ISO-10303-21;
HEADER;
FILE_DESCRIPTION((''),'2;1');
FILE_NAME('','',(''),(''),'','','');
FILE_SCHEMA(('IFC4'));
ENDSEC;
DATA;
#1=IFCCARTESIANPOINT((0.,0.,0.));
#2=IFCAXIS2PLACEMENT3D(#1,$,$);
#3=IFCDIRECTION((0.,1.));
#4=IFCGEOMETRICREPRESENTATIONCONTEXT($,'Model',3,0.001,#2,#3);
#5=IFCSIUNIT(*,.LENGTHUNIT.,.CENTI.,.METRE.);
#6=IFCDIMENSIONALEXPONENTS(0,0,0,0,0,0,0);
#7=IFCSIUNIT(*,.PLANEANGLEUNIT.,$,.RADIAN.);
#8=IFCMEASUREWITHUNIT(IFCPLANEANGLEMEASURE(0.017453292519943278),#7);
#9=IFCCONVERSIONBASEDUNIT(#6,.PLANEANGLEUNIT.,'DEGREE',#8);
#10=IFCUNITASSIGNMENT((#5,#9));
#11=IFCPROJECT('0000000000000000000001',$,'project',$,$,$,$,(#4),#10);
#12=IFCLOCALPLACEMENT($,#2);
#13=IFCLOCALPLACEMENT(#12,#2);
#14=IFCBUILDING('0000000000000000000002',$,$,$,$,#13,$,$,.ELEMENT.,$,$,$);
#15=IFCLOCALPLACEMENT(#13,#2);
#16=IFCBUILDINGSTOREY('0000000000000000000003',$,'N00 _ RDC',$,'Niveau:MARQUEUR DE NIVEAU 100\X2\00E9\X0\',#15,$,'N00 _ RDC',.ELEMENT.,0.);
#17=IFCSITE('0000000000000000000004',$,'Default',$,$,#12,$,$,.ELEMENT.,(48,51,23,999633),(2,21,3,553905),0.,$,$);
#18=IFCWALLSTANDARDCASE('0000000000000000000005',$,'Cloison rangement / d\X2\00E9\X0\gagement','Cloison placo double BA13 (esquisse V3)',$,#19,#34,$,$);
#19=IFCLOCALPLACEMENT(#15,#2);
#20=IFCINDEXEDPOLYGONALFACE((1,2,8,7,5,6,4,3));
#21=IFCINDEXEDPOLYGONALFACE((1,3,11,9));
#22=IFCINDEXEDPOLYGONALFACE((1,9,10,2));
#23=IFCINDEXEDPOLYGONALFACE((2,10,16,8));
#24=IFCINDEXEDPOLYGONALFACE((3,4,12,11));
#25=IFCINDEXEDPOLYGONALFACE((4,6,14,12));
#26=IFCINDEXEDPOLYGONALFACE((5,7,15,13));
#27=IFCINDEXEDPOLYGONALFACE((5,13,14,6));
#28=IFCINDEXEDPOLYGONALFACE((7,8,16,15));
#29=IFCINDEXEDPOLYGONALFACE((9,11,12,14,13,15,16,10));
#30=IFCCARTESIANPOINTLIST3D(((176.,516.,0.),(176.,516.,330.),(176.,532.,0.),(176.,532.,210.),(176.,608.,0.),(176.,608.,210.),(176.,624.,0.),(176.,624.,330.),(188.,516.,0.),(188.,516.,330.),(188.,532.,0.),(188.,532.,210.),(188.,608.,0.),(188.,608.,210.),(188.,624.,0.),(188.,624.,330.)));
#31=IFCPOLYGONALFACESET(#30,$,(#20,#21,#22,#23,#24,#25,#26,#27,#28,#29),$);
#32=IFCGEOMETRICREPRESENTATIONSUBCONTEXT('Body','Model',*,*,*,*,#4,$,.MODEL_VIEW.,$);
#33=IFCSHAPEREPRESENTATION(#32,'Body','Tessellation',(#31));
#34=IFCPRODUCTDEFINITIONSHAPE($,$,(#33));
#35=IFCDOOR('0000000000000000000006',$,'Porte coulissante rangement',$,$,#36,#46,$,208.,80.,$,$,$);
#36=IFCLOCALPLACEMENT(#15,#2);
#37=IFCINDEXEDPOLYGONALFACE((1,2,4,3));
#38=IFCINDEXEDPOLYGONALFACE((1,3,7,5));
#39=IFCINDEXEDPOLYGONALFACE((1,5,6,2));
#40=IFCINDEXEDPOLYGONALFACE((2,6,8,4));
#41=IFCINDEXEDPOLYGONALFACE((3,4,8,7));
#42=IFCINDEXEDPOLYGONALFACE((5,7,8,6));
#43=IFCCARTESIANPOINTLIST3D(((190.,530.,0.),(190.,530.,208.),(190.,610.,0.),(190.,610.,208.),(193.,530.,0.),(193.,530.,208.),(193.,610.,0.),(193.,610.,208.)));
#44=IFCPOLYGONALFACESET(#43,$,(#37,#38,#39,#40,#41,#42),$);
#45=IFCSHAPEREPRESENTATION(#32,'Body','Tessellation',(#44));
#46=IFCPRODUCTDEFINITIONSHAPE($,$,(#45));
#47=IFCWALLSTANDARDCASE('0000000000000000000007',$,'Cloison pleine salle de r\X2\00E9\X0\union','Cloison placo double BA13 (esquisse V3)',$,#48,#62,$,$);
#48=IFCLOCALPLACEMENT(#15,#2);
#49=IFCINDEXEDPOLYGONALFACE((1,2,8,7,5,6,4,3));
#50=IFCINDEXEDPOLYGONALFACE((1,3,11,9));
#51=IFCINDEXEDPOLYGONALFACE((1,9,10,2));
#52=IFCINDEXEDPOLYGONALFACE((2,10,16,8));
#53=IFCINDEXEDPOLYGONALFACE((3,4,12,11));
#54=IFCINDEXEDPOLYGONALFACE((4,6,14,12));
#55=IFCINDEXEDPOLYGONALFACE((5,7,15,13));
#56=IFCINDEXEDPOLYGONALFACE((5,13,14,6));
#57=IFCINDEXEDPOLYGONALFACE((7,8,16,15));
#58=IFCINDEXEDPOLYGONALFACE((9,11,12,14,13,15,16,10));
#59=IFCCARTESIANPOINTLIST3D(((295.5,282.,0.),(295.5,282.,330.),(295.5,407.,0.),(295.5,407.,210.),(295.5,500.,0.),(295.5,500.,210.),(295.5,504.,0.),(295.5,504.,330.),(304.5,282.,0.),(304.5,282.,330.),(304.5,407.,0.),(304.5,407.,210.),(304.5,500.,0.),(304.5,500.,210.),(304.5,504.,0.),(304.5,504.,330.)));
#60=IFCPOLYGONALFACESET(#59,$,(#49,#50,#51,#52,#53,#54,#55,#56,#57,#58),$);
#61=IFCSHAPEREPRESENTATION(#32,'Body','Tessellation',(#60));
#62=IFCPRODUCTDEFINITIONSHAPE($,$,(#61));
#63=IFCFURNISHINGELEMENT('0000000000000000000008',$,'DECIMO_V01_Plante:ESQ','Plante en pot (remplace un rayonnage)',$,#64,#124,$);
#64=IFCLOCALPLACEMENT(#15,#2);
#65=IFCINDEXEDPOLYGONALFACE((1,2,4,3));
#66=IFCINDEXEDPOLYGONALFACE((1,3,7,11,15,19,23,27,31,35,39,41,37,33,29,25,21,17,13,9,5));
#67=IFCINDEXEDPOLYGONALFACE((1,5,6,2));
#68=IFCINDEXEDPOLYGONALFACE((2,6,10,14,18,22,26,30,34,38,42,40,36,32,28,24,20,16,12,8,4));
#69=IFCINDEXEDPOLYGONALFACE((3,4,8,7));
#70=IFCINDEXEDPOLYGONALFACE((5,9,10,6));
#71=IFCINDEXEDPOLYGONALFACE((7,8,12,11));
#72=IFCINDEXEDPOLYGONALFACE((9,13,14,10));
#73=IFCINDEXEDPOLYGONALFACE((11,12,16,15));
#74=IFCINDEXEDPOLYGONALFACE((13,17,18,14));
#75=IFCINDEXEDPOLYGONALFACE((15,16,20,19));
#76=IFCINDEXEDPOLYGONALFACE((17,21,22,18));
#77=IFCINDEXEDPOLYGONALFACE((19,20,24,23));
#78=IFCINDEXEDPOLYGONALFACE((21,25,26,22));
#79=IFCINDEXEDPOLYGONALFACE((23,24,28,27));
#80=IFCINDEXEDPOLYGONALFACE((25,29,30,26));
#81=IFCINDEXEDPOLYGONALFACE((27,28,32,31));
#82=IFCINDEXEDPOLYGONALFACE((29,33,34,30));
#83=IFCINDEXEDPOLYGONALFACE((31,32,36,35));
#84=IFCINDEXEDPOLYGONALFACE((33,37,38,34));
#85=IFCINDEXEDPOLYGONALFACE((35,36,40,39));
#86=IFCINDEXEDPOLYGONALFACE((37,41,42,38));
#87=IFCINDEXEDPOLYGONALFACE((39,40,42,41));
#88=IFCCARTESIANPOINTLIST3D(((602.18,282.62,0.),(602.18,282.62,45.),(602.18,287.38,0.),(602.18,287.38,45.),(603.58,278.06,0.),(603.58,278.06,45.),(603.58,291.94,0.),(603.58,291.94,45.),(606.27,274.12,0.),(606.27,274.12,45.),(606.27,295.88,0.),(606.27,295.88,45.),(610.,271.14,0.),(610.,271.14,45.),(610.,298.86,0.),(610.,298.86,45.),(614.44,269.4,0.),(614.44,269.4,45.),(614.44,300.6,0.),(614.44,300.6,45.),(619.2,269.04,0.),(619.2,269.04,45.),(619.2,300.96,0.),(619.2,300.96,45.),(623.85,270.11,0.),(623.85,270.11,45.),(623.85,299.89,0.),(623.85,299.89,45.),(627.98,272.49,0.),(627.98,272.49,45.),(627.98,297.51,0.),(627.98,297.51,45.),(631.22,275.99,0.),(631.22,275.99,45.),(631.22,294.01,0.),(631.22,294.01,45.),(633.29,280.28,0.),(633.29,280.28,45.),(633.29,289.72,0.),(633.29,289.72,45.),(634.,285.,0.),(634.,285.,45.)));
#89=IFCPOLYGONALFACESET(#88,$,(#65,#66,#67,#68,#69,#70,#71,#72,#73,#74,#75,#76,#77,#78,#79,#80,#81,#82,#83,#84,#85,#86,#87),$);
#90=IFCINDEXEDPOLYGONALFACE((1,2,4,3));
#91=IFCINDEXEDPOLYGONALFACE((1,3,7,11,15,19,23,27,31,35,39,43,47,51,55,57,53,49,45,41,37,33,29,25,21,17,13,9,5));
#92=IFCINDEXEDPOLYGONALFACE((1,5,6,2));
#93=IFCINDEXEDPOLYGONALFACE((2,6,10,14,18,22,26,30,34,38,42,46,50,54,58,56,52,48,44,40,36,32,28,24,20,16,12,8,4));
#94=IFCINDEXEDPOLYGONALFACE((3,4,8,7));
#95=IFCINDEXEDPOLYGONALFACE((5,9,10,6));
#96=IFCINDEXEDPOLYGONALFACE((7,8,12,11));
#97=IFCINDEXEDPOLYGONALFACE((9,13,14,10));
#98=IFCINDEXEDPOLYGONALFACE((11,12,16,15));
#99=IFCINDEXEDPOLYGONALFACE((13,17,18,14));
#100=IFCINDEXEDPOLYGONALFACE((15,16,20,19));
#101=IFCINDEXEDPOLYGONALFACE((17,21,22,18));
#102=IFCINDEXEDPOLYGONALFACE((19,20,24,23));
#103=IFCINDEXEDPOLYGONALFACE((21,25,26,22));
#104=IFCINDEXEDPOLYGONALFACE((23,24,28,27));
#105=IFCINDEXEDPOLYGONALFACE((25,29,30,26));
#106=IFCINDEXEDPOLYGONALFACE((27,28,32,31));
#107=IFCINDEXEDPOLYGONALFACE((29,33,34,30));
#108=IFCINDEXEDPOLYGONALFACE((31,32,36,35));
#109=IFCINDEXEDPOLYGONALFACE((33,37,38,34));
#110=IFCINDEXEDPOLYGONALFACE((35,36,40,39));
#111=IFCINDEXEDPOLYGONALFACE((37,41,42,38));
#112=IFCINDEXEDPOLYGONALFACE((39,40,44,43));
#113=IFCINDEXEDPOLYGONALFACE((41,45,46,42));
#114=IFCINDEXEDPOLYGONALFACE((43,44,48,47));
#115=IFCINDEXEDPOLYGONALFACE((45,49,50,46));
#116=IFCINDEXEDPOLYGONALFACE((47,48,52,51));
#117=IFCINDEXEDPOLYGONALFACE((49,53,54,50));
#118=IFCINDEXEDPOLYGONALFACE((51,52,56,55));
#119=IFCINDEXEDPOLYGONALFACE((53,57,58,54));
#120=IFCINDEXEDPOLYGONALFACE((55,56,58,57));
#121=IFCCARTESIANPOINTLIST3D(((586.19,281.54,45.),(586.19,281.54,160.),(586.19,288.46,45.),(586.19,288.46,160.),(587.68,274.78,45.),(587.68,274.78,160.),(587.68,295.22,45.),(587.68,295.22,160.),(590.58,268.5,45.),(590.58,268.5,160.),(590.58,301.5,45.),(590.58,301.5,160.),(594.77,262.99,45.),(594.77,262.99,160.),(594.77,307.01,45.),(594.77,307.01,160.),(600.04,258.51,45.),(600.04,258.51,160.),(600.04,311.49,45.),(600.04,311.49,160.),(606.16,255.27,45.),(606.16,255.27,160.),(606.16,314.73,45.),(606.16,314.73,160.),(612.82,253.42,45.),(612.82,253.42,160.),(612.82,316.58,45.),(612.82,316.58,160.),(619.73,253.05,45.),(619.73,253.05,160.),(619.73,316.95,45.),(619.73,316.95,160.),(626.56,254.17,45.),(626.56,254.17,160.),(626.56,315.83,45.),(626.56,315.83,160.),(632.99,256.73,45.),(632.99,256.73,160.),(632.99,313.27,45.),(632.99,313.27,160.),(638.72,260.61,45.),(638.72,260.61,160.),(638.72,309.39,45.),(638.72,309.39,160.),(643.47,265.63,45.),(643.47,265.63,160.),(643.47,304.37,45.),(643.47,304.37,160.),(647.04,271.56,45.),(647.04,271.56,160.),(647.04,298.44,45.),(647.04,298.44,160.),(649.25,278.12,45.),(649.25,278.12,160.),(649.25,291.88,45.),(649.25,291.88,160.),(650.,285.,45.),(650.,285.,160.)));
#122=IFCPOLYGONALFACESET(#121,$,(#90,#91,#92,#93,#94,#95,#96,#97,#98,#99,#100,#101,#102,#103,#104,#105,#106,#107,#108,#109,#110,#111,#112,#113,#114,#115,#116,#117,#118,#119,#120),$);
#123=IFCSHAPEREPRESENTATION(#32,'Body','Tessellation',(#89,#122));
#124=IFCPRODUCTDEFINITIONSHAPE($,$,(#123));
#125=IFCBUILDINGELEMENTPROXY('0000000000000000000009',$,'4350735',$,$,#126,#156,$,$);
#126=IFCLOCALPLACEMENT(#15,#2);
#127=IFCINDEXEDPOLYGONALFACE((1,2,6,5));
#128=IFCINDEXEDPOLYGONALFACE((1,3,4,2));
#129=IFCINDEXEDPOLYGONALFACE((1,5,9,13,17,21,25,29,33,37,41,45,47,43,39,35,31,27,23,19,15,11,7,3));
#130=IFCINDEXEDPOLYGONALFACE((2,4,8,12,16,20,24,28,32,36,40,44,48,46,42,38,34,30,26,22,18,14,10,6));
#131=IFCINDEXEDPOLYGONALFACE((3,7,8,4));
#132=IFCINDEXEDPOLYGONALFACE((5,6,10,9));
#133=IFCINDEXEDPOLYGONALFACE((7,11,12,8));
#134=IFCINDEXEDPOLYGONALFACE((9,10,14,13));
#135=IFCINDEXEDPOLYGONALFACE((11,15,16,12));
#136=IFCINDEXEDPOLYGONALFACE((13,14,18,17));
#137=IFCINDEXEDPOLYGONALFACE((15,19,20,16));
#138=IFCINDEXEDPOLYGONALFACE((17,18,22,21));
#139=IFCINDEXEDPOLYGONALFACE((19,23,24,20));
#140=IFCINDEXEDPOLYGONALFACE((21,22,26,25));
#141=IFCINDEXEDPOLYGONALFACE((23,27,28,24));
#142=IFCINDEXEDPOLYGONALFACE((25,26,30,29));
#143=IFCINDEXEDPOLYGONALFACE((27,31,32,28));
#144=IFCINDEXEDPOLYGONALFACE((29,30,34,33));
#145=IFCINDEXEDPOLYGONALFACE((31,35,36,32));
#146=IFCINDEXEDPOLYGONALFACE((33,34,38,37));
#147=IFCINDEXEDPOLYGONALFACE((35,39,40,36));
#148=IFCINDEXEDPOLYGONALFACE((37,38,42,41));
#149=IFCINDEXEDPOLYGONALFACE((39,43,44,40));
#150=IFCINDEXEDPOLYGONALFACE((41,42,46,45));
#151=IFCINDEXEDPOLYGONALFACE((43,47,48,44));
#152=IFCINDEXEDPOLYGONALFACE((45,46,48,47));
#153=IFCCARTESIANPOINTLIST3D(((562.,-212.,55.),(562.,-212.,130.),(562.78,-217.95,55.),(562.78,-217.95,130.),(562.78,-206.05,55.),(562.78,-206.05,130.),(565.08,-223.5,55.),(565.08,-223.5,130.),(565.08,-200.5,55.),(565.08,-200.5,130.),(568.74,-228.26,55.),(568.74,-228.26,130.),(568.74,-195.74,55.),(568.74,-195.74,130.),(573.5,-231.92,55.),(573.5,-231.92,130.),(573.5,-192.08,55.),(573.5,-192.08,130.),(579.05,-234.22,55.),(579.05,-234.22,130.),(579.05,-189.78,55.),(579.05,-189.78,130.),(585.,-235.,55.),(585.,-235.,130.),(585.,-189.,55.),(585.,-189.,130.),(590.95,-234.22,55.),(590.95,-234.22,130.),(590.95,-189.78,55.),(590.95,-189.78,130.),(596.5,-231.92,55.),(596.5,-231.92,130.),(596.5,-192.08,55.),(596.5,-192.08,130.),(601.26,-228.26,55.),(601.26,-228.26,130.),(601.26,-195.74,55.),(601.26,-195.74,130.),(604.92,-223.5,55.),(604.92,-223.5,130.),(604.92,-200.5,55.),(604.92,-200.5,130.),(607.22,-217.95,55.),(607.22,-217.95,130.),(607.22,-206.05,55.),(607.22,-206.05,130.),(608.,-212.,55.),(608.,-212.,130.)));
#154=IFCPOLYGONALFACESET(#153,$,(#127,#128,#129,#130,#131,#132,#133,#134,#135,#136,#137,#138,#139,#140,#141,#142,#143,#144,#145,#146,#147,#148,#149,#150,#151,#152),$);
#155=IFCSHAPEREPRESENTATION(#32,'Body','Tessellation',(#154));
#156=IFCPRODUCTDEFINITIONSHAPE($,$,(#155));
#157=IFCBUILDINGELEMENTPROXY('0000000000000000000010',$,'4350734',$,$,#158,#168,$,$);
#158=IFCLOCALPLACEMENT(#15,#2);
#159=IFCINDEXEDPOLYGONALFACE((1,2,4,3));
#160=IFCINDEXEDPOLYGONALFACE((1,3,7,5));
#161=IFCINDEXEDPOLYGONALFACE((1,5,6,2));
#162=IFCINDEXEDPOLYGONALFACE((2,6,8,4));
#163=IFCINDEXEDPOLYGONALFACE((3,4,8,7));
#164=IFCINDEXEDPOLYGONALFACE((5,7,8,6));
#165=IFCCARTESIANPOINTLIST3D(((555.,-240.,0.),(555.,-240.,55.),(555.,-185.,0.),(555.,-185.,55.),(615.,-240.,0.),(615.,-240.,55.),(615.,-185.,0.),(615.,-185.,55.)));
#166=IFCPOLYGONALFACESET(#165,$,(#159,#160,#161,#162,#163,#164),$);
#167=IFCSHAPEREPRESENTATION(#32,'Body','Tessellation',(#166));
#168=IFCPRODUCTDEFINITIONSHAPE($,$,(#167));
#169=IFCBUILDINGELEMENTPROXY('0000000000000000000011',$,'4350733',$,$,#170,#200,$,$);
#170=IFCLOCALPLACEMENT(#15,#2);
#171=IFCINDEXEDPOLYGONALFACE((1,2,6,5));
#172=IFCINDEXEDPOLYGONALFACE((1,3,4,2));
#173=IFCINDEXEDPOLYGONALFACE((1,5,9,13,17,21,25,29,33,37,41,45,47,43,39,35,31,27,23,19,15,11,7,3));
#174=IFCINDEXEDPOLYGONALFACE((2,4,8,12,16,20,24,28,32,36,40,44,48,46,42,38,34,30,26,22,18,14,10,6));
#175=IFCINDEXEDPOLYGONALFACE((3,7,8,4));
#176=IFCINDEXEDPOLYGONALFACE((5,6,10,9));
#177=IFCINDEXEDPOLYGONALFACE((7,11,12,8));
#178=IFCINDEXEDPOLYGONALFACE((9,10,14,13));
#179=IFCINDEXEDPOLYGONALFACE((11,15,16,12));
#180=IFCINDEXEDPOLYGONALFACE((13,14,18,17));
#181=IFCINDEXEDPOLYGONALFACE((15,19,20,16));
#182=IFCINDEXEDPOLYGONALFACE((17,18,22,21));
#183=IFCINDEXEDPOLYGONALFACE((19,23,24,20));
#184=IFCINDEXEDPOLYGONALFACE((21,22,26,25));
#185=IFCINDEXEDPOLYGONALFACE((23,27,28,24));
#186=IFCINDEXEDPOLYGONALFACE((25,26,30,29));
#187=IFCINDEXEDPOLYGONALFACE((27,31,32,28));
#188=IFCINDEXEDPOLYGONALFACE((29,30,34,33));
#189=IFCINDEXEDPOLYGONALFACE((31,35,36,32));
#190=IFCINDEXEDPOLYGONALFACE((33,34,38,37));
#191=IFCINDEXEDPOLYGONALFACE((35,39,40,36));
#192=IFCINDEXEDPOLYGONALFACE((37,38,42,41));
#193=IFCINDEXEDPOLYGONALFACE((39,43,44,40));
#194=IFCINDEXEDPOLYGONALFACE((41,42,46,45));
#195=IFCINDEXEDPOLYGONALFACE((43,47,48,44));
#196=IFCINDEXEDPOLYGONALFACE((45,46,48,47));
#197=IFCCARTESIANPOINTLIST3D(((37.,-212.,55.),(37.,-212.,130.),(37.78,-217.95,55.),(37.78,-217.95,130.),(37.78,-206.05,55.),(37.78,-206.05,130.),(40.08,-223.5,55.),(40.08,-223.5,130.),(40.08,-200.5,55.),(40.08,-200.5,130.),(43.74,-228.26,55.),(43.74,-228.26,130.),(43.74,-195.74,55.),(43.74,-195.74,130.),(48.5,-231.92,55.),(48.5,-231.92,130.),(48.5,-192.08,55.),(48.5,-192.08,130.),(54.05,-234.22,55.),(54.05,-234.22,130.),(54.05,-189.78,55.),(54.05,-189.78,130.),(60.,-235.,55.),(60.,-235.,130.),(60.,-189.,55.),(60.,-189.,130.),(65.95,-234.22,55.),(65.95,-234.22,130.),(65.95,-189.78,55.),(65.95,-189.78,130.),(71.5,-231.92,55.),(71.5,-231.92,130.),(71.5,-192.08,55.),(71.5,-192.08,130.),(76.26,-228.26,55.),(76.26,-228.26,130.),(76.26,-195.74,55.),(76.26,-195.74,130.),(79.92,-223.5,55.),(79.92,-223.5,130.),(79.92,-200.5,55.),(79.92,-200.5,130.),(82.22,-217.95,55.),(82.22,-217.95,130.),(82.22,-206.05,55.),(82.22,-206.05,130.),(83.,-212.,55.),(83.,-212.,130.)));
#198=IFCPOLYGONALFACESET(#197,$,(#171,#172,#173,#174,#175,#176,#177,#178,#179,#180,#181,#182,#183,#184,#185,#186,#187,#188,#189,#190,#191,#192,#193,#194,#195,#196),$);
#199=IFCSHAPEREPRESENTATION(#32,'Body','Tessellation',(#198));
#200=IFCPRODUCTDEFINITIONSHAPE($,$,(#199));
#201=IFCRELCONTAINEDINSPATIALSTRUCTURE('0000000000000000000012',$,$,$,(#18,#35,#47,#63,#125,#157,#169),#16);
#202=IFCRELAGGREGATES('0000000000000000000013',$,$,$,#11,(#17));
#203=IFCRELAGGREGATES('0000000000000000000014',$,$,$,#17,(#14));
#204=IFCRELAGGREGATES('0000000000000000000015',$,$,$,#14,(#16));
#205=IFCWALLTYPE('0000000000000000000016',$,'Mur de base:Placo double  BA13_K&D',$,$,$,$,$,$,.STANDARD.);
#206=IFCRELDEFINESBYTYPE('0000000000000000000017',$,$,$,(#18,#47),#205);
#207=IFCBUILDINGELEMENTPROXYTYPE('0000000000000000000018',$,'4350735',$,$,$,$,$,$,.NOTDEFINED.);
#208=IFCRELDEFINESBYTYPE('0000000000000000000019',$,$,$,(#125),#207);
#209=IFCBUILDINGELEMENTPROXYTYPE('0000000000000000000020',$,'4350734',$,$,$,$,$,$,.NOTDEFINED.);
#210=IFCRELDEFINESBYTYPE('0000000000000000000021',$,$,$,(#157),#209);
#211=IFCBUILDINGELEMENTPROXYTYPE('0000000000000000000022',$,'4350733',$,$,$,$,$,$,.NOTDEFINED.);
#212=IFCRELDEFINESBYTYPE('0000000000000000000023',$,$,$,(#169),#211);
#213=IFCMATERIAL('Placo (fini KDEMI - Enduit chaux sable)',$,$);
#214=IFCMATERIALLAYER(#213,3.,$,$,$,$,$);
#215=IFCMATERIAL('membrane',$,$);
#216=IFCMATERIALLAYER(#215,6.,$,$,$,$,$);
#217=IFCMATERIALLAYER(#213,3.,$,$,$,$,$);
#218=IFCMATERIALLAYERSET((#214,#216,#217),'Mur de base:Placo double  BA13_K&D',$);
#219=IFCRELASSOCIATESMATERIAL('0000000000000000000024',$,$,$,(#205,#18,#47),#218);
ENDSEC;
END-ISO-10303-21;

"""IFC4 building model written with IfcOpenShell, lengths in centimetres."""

from ifc_helpers import new_model, entity, si_unit, converted_unit, direction, frame, frame_2d, origin, origin_with_axes, origin_2d_with_axis, place, context, subcontext, project, spatial, rectangle, circle, extrude, material, layer, layer_set, layer_usage, type_object, element, fill, save


model = new_model("IFC4")

# Units and contexts
model_context = context("Model", 3, precision=0.001, world=origin(), true_north=direction((0.0, 1.0)))
body_context = subcontext(model_context, "Body", "Model", "MODEL_VIEW")
ifc_project = project(units=[si_unit("LENGTHUNIT", "METRE", prefix="CENTI"), converted_unit("PLANEANGLEUNIT", "DEGREE", entity("IfcPlaneAngleMeasure", 0.017453292519943278), si_unit("PLANEANGLEUNIT", "RADIAN"), dimensions=[0, 0, 0, 0, 0, 0, 0])], contexts=[model_context])

# Site, building, storey
site_placement = place(None, origin())
site = spatial("IfcSite", under=ifc_project, at=site_placement, Name="Default", CompositionType="ELEMENT", RefLatitude=(48, 51, 23, 999633), RefLongitude=(2, 21, 3, 553905), RefElevation=0.0)
building_placement = place(site_placement, origin())
building = spatial("IfcBuilding", under=site, at=building_placement, CompositionType="ELEMENT")
storey_placement = place(building_placement, origin())
storey = spatial("IfcBuildingStorey", under=building, at=storey_placement, Name="N00 _ RDC", ObjectType="Niveau:MARQUEUR DE NIVEAU 100é", LongName="N00 _ RDC", CompositionType="ELEMENT", Elevation=0.0)

# Wall, opening, door
ifc_material_1 = material(Name="Placo (fini KDEMI - Enduit chaux sable)")
ifc_layer_1 = layer(ifc_material_1, 3.0)
ifc_material_2 = material(Name="membrane")
ifc_layer_2 = layer(ifc_material_2, 6.0)
ifc_layer_3 = layer(ifc_material_1, 3.0)
ifc_layer_set = layer_set([ifc_layer_1, ifc_layer_2, ifc_layer_3], Name="Mur de base:Placo double  BA13_K&D")
ifc_layer_usage_1 = layer_usage(ifc_layer_set, "AXIS2", "POSITIVE", 0.0)
wall_type = type_object("IfcWallType", Name="Mur de base:Placo double  BA13_K&D", PredefinedType="STANDARD", material=ifc_layer_set)
wall_1_placement = place(storey_placement, origin_with_axes())
wall_1 = element("IfcWallStandardCase", 1, at=wall_1_placement, inside=storey, type_object=wall_type, material=ifc_layer_usage_1, Name="Cloison rangement / dégagement", Description="Cloison placo double BA13 (esquisse V3)", context=body_context, shape_type="SweptSolid", body=[
    extrude(rectangle(XDim=12.0, YDim=108.0, at=frame_2d((182.0, 570.0))), origin(), (0.0, 0.0, 1.0), 330.0),
])
opening_1_placement = place(wall_1_placement, origin_with_axes())
opening_1 = element("IfcOpeningElement", 2, at=opening_1_placement, inside=storey, cuts=wall_1, context=body_context, shape_type="SweptSolid", body=[
    extrude(rectangle(XDim=16.0, YDim=76.0, at=frame_2d((182.0, 570.0))), origin(), (0.0, 0.0, 1.0), 210.0),
])
door_placement = place(storey_placement, origin_with_axes())
door = element("IfcDoor", 3, at=door_placement, inside=storey, Name="Porte coulissante rangement", OverallHeight=208.0, OverallWidth=80.0, context=body_context, shape_type="SweptSolid", body=[
    extrude(rectangle(XDim=3.0, YDim=80.0, at=frame_2d((191.5, 570.0))), origin(), (0.0, 0.0, 1.0), 208.0),
])
fill(opening_1, door)

# Wall, opening
ifc_layer_usage_2 = layer_usage(ifc_layer_set, "AXIS2", "POSITIVE", 0.0)
wall_2_placement = place(storey_placement, origin_with_axes())
wall_2 = element("IfcWallStandardCase", 4, at=wall_2_placement, inside=storey, type_object=wall_type, material=ifc_layer_usage_2, Name="Cloison pleine salle de réunion", Description="Cloison placo double BA13 (esquisse V3)", context=body_context, shape_type="SweptSolid", body=[
    extrude(rectangle(XDim=9.0, YDim=222.0, at=frame_2d((300.0, 393.0))), origin(), (0.0, 0.0, 1.0), 330.0),
])
opening_2_placement = place(wall_2_placement, origin_with_axes())
element("IfcOpeningElement", 5, at=opening_2_placement, inside=storey, cuts=wall_2, context=body_context, shape_type="SweptSolid", body=[
    extrude(rectangle(XDim=12.0, YDim=93.0, at=frame_2d((300.0, 453.5))), origin(), (0.0, 0.0, 1.0), 210.0),
])

# Furnishing element
furnishing_placement = place(storey_placement, origin_with_axes())
element("IfcFurnishingElement", 6, at=furnishing_placement, inside=storey, Name="DECIMO_V01_Plante:ESQ", Description="Plante en pot (remplace un rayonnage)", context=body_context, shape_type="SweptSolid", body=[
    extrude(circle(Radius=16.0, at=frame_2d((618.0, 285.0))), origin(), (0.0, 0.0, 1.0), 45.0),
    extrude(circle(Radius=32.0, at=frame_2d((618.0, 285.0))), frame((0.0, 0.0, 45.0)), (0.0, 0.0, 1.0), 115.0),
])

# Building element proxies
building_element_proxy_type_1 = type_object("IfcBuildingElementProxyType", Name="4350735", PredefinedType="NOTDEFINED")
proxy_1_placement = place(storey_placement, origin())
element("IfcBuildingElementProxy", 7, at=proxy_1_placement, inside=storey, type_object=building_element_proxy_type_1, Name="4350735", context=body_context, shape_type="SweptSolid", body=[
    extrude(circle(Radius=23.0, at=origin_2d_with_axis()), frame((585.0, -212.0, 55.0)), (0.0, 0.0, 1.0), 75.0),
])
building_element_proxy_type_2 = type_object("IfcBuildingElementProxyType", Name="4350734", PredefinedType="NOTDEFINED")
proxy_2_placement = place(storey_placement, origin())
element("IfcBuildingElementProxy", 8, at=proxy_2_placement, inside=storey, type_object=building_element_proxy_type_2, Name="4350734", context=body_context, shape_type="SweptSolid", body=[
    extrude(rectangle(XDim=60.0, YDim=55.0, at=origin_2d_with_axis()), frame((585.0, -212.5, 0.0)), (0.0, 0.0, 1.0), 55.0),
])
building_element_proxy_type_3 = type_object("IfcBuildingElementProxyType", Name="4350733", PredefinedType="NOTDEFINED")
proxy_3_placement = place(storey_placement, origin())
element("IfcBuildingElementProxy", 9, at=proxy_3_placement, inside=storey, type_object=building_element_proxy_type_3, Name="4350733", context=body_context, shape_type="SweptSolid", body=[
    extrude(circle(Radius=23.0, at=origin_2d_with_axis()), frame((60.0, -212.0, 55.0)), (0.0, 0.0, 1.0), 75.0),
])

save(model, "model.ifc")
